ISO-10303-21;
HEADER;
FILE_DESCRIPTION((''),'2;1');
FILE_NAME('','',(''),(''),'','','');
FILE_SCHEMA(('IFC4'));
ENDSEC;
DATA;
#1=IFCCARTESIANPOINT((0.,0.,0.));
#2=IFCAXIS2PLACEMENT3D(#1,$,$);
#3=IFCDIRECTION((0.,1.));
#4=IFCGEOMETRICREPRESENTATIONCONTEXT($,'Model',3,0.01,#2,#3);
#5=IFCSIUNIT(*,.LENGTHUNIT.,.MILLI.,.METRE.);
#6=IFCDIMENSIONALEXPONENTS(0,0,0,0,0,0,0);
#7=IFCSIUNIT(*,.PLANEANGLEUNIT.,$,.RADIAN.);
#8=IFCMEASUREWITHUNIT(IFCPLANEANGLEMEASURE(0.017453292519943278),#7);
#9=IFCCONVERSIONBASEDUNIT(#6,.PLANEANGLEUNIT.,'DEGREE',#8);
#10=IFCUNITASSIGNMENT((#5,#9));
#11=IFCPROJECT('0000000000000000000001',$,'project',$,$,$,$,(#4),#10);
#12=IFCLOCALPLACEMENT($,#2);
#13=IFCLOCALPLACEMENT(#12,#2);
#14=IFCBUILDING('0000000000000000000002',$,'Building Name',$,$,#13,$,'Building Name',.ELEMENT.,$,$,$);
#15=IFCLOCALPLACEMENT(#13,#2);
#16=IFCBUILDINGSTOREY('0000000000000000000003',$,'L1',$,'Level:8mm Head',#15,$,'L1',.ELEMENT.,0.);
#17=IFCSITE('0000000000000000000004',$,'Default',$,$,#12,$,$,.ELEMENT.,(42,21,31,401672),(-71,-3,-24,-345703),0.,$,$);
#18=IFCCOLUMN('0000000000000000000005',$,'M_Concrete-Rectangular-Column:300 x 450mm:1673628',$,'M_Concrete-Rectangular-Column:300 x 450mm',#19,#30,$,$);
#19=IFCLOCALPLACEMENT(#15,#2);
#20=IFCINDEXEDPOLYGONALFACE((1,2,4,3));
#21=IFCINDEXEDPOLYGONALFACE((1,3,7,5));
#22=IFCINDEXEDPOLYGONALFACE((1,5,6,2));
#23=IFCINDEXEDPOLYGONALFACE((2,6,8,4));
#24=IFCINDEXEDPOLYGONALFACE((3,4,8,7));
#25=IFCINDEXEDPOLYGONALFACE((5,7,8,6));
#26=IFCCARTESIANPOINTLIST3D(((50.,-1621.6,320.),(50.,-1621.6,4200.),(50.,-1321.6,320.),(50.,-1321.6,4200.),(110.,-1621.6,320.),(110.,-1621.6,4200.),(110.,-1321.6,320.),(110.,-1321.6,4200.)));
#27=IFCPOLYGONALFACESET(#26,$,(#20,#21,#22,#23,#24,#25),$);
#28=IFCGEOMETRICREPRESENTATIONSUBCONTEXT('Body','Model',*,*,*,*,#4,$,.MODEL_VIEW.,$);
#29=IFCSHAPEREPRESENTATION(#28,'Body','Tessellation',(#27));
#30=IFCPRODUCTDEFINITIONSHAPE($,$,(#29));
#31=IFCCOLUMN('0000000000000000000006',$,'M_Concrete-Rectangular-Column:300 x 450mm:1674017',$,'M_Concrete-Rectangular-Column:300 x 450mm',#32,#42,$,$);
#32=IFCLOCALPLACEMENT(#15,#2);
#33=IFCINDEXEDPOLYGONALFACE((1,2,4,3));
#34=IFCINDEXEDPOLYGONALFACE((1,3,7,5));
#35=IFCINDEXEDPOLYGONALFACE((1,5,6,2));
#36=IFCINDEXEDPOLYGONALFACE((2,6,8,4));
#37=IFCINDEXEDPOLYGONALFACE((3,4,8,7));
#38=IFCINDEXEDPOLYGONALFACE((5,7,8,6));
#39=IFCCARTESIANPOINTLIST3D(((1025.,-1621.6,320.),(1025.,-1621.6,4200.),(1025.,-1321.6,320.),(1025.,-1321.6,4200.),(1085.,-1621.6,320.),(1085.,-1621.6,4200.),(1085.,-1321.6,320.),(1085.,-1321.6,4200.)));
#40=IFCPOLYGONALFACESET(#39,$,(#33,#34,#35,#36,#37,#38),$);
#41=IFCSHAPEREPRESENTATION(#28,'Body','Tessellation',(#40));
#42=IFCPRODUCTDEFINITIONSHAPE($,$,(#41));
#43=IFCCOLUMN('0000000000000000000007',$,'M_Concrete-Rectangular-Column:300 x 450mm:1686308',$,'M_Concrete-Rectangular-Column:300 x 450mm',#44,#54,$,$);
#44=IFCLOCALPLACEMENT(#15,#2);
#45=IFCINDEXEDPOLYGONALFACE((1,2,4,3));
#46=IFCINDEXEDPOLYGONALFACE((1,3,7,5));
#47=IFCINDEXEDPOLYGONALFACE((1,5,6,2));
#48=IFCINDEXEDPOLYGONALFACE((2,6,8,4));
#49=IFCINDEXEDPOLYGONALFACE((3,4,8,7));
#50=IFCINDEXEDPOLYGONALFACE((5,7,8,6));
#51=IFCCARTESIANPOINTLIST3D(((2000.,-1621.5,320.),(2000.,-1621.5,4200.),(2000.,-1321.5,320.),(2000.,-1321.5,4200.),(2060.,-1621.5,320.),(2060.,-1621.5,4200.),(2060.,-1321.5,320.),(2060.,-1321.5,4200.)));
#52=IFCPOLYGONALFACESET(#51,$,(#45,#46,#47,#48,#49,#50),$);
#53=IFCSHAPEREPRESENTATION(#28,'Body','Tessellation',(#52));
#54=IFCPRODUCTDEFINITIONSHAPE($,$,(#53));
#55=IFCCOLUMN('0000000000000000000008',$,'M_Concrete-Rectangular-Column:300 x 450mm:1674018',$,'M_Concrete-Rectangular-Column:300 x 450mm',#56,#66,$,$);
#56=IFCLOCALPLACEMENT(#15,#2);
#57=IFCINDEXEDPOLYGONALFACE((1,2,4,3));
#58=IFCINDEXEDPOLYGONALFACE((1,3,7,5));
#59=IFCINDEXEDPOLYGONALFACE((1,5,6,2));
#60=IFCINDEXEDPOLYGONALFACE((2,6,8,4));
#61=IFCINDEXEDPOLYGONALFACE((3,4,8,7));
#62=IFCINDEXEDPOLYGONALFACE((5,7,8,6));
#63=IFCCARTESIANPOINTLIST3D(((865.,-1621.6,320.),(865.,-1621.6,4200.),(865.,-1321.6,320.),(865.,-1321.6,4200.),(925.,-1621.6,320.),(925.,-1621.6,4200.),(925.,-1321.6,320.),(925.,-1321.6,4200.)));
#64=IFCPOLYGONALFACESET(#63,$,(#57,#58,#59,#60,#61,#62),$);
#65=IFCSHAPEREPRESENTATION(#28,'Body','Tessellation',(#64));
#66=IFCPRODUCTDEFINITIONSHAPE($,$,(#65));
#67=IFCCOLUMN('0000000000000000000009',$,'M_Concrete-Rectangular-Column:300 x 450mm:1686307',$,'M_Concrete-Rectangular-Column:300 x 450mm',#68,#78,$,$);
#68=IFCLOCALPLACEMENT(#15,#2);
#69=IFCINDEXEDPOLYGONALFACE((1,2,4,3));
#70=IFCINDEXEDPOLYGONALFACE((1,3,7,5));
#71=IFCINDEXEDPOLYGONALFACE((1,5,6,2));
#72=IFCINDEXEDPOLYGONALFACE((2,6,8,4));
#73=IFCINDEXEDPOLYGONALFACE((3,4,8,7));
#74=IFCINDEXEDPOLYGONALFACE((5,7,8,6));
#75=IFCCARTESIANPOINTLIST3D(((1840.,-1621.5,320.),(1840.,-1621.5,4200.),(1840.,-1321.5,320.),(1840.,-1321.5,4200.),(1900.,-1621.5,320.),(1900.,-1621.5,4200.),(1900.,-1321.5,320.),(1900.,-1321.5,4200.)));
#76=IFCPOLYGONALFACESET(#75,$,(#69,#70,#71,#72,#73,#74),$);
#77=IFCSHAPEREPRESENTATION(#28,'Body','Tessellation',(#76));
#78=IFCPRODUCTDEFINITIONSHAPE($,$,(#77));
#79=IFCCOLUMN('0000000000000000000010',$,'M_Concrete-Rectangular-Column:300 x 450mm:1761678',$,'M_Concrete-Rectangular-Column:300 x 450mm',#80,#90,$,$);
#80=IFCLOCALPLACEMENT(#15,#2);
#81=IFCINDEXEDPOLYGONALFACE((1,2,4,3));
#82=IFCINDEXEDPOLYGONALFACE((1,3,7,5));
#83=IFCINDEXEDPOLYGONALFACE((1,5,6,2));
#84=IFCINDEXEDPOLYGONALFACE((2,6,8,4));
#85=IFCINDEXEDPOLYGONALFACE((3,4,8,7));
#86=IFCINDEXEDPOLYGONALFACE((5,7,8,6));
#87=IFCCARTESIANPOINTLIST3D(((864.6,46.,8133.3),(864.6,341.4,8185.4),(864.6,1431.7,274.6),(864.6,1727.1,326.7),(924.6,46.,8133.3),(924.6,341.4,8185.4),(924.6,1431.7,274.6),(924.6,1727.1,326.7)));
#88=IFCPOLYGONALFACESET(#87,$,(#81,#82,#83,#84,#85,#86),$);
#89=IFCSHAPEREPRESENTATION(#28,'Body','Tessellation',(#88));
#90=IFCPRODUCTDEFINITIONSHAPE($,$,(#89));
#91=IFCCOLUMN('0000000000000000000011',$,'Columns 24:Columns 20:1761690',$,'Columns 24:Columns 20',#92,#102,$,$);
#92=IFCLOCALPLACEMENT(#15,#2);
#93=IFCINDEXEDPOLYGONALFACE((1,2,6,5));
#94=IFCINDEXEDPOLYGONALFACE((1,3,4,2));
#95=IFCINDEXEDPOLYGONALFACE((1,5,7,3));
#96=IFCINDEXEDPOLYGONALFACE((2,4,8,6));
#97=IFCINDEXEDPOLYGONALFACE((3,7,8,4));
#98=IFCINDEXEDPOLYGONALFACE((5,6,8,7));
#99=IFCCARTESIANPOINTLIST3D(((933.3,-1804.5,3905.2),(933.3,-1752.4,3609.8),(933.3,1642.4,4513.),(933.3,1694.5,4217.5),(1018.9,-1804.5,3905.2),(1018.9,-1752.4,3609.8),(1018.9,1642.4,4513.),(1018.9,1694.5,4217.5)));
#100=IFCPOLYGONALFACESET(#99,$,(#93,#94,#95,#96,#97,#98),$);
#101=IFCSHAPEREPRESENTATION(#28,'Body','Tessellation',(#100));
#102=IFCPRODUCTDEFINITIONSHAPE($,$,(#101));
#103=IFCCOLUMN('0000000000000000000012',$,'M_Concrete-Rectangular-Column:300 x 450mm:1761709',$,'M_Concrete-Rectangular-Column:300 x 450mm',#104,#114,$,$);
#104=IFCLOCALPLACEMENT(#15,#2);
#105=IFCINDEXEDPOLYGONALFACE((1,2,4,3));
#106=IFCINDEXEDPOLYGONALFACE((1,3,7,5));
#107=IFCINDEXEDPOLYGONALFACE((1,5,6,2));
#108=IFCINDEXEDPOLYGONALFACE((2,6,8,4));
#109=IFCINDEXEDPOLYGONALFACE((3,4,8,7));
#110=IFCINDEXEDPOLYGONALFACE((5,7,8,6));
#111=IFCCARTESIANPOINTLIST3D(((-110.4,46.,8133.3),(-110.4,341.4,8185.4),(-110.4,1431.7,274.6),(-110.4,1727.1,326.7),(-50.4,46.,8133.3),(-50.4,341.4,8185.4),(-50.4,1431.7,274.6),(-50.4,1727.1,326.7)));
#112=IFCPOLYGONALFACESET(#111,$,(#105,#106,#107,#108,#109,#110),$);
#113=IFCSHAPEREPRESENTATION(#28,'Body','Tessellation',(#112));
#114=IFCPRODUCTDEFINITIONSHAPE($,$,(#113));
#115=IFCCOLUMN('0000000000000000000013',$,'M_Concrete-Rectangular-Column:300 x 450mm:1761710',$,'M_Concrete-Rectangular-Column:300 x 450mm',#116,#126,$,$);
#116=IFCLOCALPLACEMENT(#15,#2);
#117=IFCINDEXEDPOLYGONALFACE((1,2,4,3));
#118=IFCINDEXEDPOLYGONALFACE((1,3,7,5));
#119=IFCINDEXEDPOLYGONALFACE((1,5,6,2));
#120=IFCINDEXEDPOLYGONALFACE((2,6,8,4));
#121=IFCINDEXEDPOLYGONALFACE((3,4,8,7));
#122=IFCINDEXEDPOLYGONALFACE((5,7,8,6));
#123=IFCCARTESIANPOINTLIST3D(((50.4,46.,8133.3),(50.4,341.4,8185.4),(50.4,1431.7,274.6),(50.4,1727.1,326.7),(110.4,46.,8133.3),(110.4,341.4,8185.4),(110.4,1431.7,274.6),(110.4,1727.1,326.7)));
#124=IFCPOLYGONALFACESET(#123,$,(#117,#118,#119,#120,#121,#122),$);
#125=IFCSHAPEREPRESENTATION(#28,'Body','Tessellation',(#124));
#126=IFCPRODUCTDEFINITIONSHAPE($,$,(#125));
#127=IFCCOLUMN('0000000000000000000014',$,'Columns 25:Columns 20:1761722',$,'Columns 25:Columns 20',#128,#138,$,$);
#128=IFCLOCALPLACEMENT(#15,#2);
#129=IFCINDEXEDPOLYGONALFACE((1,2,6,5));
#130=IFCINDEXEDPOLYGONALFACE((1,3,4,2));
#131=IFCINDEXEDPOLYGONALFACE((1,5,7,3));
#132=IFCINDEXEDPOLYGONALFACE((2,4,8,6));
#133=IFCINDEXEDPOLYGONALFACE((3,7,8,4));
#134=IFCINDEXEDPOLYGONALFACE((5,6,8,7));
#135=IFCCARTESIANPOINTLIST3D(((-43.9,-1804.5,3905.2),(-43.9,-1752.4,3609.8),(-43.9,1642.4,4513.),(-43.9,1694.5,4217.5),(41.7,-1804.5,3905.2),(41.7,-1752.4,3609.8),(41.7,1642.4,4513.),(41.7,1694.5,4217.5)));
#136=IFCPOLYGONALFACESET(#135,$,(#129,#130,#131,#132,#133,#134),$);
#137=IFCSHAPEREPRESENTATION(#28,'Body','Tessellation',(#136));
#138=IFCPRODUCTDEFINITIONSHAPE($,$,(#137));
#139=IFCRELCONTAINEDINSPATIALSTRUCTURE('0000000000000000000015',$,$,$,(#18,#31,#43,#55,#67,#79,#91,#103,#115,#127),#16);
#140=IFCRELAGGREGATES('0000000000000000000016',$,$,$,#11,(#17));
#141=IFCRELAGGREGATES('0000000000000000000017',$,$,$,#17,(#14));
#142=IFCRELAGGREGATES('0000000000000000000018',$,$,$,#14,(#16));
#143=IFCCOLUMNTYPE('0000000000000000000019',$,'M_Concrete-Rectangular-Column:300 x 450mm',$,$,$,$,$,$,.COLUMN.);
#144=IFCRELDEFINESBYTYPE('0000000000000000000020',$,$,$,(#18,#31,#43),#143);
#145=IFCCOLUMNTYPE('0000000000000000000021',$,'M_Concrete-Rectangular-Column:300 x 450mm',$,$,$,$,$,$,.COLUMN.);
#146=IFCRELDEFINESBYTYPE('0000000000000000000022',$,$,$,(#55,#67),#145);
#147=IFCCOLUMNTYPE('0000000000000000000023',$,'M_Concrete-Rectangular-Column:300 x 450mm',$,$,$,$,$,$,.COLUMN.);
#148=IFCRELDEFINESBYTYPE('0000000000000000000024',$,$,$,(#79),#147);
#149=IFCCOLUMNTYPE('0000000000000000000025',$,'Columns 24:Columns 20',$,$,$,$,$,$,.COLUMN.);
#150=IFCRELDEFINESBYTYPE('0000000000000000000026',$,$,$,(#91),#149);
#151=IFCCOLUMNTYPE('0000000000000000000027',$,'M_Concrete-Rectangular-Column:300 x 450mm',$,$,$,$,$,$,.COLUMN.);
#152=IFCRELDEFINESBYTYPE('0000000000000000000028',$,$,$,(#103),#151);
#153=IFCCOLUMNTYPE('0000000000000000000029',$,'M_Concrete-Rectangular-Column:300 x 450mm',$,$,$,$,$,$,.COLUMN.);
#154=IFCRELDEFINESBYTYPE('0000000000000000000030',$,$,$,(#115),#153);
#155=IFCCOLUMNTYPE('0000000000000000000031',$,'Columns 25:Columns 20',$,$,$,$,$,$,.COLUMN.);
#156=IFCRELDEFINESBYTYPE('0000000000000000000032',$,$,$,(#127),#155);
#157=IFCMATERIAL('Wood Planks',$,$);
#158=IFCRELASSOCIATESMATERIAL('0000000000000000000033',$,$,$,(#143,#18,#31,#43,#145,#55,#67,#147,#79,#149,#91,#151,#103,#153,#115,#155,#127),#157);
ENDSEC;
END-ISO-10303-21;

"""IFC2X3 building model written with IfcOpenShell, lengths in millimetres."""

from ifc_helpers import new_model, entity, si_unit, converted_unit, direction, frame, frame_2d, origin, origin_2d_with_axis, place, context, subcontext, project, spatial, rectangle, extrude, source, transform, mapped, material, type_object, type_shapes, element, save


model = new_model("IFC2X3")

# Units and contexts
model_context = context("Model", 3, precision=0.01, world=origin(), true_north=direction((0.0, 1.0)))
body_context = subcontext(model_context, "Body", "Model", "MODEL_VIEW")
ifc_project = project(units=[si_unit("LENGTHUNIT", "METRE", prefix="MILLI"), converted_unit("PLANEANGLEUNIT", "DEGREE", entity("IfcPlaneAngleMeasure", 0.017453292519943278), si_unit("PLANEANGLEUNIT", "RADIAN"), dimensions=[0, 0, 0, 0, 0, 0, 0])], contexts=[model_context])

# Site, building, storey
site_placement = place(None, origin())
site = spatial("IfcSite", under=ifc_project, at=site_placement, Name="Default", CompositionType="ELEMENT", RefLatitude=(42, 21, 31, 401672), RefLongitude=(-71, -3, -24, -345703), RefElevation=0.0)
building_placement = place(site_placement, origin())
building = spatial("IfcBuilding", under=site, at=building_placement, Name="Building Name", LongName="Building Name", CompositionType="ELEMENT")
storey_placement = place(building_placement, origin())
storey = spatial("IfcBuildingStorey", under=building, at=storey_placement, Name="L1", ObjectType="Level:8mm Head", LongName="L1", CompositionType="ELEMENT", Elevation=0.0)

# Columns
ifc_material_1 = material(Name="Wood Planks")
column_type_1 = type_object("IfcColumnType", Name="M_Concrete-Rectangular-Column:300 x 450mm", PredefinedType="COLUMN", material=ifc_material_1)
shared_shape_1 = source(origin(), body_context, "Body", "SweptSolid", [
    extrude(rectangle(XDim=300.0, YDim=60.0, at=origin_2d_with_axis()), frame((0.0, 0.0, 320.0), z_axis=(0.0, 0.0, 1.0), x_axis=(0.0, 1.0, 0.0)), (0.0, 0.0, 1.0), 3880.0),
])
type_shapes(column_type_1, [shared_shape_1])
for number, where, z_axis, x_axis, name in (
    (1, (80.0, -1471.6, 0.0), (0.0, 0.0, 1.0), (-1.0, 0.0, 0.0), "M_Concrete-Rectangular-Column:300 x 450mm:1673628"),
    (2, (1055.0, -1471.6, 0.0), (0.0, 0.0, 1.0), (-1.0, 0.0, 0.0), "M_Concrete-Rectangular-Column:300 x 450mm:1674017"),
    (3, (2030.0, -1471.5, 0.0), (0.0, 0.0, 1.0), (-1.0, 0.0, 0.0), "M_Concrete-Rectangular-Column:300 x 450mm:1686308"),
):
    element("IfcColumn", number, at=place(storey_placement, frame(where, z_axis=z_axis, x_axis=x_axis)), inside=storey, type_object=column_type_1, material=ifc_material_1, Name=name, ObjectType="M_Concrete-Rectangular-Column:300 x 450mm", context=body_context, shape_type="MappedRepresentation", body=[
        mapped(shared_shape_1, transform((0.0, 0.0, 0.0), scale=1.0)),
    ])
column_type_2 = type_object("IfcColumnType", Name="M_Concrete-Rectangular-Column:300 x 450mm", PredefinedType="COLUMN", material=ifc_material_1)
shared_shape_2 = source(origin(), body_context, "Body", "SweptSolid", [
    extrude(rectangle(XDim=60.0, YDim=300.0, at=origin_2d_with_axis()), frame((0.0, 0.0, 320.0), z_axis=(0.0, 0.0, 1.0), x_axis=(-1.0, 0.0, 0.0)), (0.0, 0.0, 1.0), 3880.0),
])
type_shapes(column_type_2, [shared_shape_2])
for number, where, name in (
    (4, (895.0, -1471.6, 0.0), "M_Concrete-Rectangular-Column:300 x 450mm:1674018"),
    (5, (1870.0, -1471.5, 0.0), "M_Concrete-Rectangular-Column:300 x 450mm:1686307"),
):
    element("IfcColumn", number, at=place(storey_placement, frame(where)), inside=storey, type_object=column_type_2, material=ifc_material_1, Name=name, ObjectType="M_Concrete-Rectangular-Column:300 x 450mm", context=body_context, shape_type="MappedRepresentation", body=[
        mapped(shared_shape_2, transform((0.0, 0.0, 0.0), scale=1.0)),
    ])
column_type_3 = type_object("IfcColumnType", Name="M_Concrete-Rectangular-Column:300 x 450mm", PredefinedType="COLUMN", material=ifc_material_1)
shared_shape_3 = source(origin(), body_context, "Body", "SweptSolid", [
    extrude(rectangle(XDim=300.0, YDim=60.0, at=origin_2d_with_axis()), frame((894.6, 1579.4, 300.6), z_axis=(0.0, -0.173648, 0.984808), x_axis=(0.0, -0.984808, -0.173648)), (0.0, 0.0, 1.0), 7980.0),
])
type_shapes(column_type_3, [shared_shape_3])
column_1_placement = place(storey_placement, origin())
element("IfcColumn", 6, at=column_1_placement, inside=storey, type_object=column_type_3, material=ifc_material_1, Name="M_Concrete-Rectangular-Column:300 x 450mm:1761678", ObjectType="M_Concrete-Rectangular-Column:300 x 450mm", context=body_context, shape_type="MappedRepresentation", body=[
    mapped(shared_shape_3, transform((0.0, 0.0, 0.0), scale=1.0)),
])
column_type_4 = type_object("IfcColumnType", Name="Columns 24:Columns 20", PredefinedType="COLUMN", material=ifc_material_1)
shared_shape_4 = source(origin(), body_context, "Body", "SweptSolid", [
    extrude(rectangle(XDim=300.0, YDim=85.6, at=frame_2d((0.0, 0.0), x_axis=(0.0, 1.0))), frame((976.1, -1778.4, 3757.5), z_axis=(0.0, 0.984808, 0.173648), x_axis=(1.0, 0.0, 0.0)), (0.0, 0.0, 1.0), 3500.0),
])
type_shapes(column_type_4, [shared_shape_4])
column_2_placement = place(storey_placement, origin())
element("IfcColumn", 7, at=column_2_placement, inside=storey, type_object=column_type_4, material=ifc_material_1, Name="Columns 24:Columns 20:1761690", ObjectType="Columns 24:Columns 20", context=body_context, shape_type="MappedRepresentation", body=[
    mapped(shared_shape_4, transform((0.0, 0.0, 0.0), scale=1.0)),
])
column_type_5 = type_object("IfcColumnType", Name="M_Concrete-Rectangular-Column:300 x 450mm", PredefinedType="COLUMN", material=ifc_material_1)
shared_shape_5 = source(origin(), body_context, "Body", "SweptSolid", [
    extrude(rectangle(XDim=300.0, YDim=60.0, at=frame_2d((0.0, 0.0), x_axis=(1.0, 0.0))), frame((-80.4, 1579.4, 300.6), z_axis=(0.0, -0.173648, 0.984808), x_axis=(0.0, -0.984808, -0.173648)), (0.0, 0.0, 1.0), 7980.0),
])
type_shapes(column_type_5, [shared_shape_5])
column_3_placement = place(storey_placement, origin())
element("IfcColumn", 8, at=column_3_placement, inside=storey, type_object=column_type_5, material=ifc_material_1, Name="M_Concrete-Rectangular-Column:300 x 450mm:1761709", ObjectType="M_Concrete-Rectangular-Column:300 x 450mm", context=body_context, shape_type="MappedRepresentation", body=[
    mapped(shared_shape_5, transform((0.0, 0.0, 0.0), scale=1.0)),
])
column_type_6 = type_object("IfcColumnType", Name="M_Concrete-Rectangular-Column:300 x 450mm", PredefinedType="COLUMN", material=ifc_material_1)
shared_shape_6 = source(origin(), body_context, "Body", "SweptSolid", [
    extrude(rectangle(XDim=300.0, YDim=60.0, at=frame_2d((0.0, 0.0), x_axis=(1.0, 0.0))), frame((80.4, 1579.4, 300.6), z_axis=(0.0, -0.173648, 0.984808), x_axis=(0.0, -0.984808, -0.173648)), (0.0, 0.0, 1.0), 7980.0),
])
type_shapes(column_type_6, [shared_shape_6])
column_4_placement = place(storey_placement, origin())
element("IfcColumn", 9, at=column_4_placement, inside=storey, type_object=column_type_6, material=ifc_material_1, Name="M_Concrete-Rectangular-Column:300 x 450mm:1761710", ObjectType="M_Concrete-Rectangular-Column:300 x 450mm", context=body_context, shape_type="MappedRepresentation", body=[
    mapped(shared_shape_6, transform((0.0, 0.0, 0.0), scale=1.0)),
])
column_type_7 = type_object("IfcColumnType", Name="Columns 25:Columns 20", PredefinedType="COLUMN", material=ifc_material_1)
shared_shape_7 = source(origin(), body_context, "Body", "SweptSolid", [
    extrude(rectangle(XDim=300.0, YDim=85.6, at=frame_2d((0.0, 0.0), x_axis=(0.0, 1.0))), frame((-1.1, -1778.4, 3757.5), z_axis=(0.0, 0.984808, 0.173648), x_axis=(-1.0, 0.0, 0.0)), (0.0, 0.0, 1.0), 3500.0),
])
type_shapes(column_type_7, [shared_shape_7])
column_5_placement = place(storey_placement, origin())
element("IfcColumn", 10, at=column_5_placement, inside=storey, type_object=column_type_7, material=ifc_material_1, Name="Columns 25:Columns 20:1761722", ObjectType="Columns 25:Columns 20", context=body_context, shape_type="MappedRepresentation", body=[
    mapped(shared_shape_7, transform((0.0, 0.0, 0.0), scale=1.0)),
])

save(model, "model.ifc")
